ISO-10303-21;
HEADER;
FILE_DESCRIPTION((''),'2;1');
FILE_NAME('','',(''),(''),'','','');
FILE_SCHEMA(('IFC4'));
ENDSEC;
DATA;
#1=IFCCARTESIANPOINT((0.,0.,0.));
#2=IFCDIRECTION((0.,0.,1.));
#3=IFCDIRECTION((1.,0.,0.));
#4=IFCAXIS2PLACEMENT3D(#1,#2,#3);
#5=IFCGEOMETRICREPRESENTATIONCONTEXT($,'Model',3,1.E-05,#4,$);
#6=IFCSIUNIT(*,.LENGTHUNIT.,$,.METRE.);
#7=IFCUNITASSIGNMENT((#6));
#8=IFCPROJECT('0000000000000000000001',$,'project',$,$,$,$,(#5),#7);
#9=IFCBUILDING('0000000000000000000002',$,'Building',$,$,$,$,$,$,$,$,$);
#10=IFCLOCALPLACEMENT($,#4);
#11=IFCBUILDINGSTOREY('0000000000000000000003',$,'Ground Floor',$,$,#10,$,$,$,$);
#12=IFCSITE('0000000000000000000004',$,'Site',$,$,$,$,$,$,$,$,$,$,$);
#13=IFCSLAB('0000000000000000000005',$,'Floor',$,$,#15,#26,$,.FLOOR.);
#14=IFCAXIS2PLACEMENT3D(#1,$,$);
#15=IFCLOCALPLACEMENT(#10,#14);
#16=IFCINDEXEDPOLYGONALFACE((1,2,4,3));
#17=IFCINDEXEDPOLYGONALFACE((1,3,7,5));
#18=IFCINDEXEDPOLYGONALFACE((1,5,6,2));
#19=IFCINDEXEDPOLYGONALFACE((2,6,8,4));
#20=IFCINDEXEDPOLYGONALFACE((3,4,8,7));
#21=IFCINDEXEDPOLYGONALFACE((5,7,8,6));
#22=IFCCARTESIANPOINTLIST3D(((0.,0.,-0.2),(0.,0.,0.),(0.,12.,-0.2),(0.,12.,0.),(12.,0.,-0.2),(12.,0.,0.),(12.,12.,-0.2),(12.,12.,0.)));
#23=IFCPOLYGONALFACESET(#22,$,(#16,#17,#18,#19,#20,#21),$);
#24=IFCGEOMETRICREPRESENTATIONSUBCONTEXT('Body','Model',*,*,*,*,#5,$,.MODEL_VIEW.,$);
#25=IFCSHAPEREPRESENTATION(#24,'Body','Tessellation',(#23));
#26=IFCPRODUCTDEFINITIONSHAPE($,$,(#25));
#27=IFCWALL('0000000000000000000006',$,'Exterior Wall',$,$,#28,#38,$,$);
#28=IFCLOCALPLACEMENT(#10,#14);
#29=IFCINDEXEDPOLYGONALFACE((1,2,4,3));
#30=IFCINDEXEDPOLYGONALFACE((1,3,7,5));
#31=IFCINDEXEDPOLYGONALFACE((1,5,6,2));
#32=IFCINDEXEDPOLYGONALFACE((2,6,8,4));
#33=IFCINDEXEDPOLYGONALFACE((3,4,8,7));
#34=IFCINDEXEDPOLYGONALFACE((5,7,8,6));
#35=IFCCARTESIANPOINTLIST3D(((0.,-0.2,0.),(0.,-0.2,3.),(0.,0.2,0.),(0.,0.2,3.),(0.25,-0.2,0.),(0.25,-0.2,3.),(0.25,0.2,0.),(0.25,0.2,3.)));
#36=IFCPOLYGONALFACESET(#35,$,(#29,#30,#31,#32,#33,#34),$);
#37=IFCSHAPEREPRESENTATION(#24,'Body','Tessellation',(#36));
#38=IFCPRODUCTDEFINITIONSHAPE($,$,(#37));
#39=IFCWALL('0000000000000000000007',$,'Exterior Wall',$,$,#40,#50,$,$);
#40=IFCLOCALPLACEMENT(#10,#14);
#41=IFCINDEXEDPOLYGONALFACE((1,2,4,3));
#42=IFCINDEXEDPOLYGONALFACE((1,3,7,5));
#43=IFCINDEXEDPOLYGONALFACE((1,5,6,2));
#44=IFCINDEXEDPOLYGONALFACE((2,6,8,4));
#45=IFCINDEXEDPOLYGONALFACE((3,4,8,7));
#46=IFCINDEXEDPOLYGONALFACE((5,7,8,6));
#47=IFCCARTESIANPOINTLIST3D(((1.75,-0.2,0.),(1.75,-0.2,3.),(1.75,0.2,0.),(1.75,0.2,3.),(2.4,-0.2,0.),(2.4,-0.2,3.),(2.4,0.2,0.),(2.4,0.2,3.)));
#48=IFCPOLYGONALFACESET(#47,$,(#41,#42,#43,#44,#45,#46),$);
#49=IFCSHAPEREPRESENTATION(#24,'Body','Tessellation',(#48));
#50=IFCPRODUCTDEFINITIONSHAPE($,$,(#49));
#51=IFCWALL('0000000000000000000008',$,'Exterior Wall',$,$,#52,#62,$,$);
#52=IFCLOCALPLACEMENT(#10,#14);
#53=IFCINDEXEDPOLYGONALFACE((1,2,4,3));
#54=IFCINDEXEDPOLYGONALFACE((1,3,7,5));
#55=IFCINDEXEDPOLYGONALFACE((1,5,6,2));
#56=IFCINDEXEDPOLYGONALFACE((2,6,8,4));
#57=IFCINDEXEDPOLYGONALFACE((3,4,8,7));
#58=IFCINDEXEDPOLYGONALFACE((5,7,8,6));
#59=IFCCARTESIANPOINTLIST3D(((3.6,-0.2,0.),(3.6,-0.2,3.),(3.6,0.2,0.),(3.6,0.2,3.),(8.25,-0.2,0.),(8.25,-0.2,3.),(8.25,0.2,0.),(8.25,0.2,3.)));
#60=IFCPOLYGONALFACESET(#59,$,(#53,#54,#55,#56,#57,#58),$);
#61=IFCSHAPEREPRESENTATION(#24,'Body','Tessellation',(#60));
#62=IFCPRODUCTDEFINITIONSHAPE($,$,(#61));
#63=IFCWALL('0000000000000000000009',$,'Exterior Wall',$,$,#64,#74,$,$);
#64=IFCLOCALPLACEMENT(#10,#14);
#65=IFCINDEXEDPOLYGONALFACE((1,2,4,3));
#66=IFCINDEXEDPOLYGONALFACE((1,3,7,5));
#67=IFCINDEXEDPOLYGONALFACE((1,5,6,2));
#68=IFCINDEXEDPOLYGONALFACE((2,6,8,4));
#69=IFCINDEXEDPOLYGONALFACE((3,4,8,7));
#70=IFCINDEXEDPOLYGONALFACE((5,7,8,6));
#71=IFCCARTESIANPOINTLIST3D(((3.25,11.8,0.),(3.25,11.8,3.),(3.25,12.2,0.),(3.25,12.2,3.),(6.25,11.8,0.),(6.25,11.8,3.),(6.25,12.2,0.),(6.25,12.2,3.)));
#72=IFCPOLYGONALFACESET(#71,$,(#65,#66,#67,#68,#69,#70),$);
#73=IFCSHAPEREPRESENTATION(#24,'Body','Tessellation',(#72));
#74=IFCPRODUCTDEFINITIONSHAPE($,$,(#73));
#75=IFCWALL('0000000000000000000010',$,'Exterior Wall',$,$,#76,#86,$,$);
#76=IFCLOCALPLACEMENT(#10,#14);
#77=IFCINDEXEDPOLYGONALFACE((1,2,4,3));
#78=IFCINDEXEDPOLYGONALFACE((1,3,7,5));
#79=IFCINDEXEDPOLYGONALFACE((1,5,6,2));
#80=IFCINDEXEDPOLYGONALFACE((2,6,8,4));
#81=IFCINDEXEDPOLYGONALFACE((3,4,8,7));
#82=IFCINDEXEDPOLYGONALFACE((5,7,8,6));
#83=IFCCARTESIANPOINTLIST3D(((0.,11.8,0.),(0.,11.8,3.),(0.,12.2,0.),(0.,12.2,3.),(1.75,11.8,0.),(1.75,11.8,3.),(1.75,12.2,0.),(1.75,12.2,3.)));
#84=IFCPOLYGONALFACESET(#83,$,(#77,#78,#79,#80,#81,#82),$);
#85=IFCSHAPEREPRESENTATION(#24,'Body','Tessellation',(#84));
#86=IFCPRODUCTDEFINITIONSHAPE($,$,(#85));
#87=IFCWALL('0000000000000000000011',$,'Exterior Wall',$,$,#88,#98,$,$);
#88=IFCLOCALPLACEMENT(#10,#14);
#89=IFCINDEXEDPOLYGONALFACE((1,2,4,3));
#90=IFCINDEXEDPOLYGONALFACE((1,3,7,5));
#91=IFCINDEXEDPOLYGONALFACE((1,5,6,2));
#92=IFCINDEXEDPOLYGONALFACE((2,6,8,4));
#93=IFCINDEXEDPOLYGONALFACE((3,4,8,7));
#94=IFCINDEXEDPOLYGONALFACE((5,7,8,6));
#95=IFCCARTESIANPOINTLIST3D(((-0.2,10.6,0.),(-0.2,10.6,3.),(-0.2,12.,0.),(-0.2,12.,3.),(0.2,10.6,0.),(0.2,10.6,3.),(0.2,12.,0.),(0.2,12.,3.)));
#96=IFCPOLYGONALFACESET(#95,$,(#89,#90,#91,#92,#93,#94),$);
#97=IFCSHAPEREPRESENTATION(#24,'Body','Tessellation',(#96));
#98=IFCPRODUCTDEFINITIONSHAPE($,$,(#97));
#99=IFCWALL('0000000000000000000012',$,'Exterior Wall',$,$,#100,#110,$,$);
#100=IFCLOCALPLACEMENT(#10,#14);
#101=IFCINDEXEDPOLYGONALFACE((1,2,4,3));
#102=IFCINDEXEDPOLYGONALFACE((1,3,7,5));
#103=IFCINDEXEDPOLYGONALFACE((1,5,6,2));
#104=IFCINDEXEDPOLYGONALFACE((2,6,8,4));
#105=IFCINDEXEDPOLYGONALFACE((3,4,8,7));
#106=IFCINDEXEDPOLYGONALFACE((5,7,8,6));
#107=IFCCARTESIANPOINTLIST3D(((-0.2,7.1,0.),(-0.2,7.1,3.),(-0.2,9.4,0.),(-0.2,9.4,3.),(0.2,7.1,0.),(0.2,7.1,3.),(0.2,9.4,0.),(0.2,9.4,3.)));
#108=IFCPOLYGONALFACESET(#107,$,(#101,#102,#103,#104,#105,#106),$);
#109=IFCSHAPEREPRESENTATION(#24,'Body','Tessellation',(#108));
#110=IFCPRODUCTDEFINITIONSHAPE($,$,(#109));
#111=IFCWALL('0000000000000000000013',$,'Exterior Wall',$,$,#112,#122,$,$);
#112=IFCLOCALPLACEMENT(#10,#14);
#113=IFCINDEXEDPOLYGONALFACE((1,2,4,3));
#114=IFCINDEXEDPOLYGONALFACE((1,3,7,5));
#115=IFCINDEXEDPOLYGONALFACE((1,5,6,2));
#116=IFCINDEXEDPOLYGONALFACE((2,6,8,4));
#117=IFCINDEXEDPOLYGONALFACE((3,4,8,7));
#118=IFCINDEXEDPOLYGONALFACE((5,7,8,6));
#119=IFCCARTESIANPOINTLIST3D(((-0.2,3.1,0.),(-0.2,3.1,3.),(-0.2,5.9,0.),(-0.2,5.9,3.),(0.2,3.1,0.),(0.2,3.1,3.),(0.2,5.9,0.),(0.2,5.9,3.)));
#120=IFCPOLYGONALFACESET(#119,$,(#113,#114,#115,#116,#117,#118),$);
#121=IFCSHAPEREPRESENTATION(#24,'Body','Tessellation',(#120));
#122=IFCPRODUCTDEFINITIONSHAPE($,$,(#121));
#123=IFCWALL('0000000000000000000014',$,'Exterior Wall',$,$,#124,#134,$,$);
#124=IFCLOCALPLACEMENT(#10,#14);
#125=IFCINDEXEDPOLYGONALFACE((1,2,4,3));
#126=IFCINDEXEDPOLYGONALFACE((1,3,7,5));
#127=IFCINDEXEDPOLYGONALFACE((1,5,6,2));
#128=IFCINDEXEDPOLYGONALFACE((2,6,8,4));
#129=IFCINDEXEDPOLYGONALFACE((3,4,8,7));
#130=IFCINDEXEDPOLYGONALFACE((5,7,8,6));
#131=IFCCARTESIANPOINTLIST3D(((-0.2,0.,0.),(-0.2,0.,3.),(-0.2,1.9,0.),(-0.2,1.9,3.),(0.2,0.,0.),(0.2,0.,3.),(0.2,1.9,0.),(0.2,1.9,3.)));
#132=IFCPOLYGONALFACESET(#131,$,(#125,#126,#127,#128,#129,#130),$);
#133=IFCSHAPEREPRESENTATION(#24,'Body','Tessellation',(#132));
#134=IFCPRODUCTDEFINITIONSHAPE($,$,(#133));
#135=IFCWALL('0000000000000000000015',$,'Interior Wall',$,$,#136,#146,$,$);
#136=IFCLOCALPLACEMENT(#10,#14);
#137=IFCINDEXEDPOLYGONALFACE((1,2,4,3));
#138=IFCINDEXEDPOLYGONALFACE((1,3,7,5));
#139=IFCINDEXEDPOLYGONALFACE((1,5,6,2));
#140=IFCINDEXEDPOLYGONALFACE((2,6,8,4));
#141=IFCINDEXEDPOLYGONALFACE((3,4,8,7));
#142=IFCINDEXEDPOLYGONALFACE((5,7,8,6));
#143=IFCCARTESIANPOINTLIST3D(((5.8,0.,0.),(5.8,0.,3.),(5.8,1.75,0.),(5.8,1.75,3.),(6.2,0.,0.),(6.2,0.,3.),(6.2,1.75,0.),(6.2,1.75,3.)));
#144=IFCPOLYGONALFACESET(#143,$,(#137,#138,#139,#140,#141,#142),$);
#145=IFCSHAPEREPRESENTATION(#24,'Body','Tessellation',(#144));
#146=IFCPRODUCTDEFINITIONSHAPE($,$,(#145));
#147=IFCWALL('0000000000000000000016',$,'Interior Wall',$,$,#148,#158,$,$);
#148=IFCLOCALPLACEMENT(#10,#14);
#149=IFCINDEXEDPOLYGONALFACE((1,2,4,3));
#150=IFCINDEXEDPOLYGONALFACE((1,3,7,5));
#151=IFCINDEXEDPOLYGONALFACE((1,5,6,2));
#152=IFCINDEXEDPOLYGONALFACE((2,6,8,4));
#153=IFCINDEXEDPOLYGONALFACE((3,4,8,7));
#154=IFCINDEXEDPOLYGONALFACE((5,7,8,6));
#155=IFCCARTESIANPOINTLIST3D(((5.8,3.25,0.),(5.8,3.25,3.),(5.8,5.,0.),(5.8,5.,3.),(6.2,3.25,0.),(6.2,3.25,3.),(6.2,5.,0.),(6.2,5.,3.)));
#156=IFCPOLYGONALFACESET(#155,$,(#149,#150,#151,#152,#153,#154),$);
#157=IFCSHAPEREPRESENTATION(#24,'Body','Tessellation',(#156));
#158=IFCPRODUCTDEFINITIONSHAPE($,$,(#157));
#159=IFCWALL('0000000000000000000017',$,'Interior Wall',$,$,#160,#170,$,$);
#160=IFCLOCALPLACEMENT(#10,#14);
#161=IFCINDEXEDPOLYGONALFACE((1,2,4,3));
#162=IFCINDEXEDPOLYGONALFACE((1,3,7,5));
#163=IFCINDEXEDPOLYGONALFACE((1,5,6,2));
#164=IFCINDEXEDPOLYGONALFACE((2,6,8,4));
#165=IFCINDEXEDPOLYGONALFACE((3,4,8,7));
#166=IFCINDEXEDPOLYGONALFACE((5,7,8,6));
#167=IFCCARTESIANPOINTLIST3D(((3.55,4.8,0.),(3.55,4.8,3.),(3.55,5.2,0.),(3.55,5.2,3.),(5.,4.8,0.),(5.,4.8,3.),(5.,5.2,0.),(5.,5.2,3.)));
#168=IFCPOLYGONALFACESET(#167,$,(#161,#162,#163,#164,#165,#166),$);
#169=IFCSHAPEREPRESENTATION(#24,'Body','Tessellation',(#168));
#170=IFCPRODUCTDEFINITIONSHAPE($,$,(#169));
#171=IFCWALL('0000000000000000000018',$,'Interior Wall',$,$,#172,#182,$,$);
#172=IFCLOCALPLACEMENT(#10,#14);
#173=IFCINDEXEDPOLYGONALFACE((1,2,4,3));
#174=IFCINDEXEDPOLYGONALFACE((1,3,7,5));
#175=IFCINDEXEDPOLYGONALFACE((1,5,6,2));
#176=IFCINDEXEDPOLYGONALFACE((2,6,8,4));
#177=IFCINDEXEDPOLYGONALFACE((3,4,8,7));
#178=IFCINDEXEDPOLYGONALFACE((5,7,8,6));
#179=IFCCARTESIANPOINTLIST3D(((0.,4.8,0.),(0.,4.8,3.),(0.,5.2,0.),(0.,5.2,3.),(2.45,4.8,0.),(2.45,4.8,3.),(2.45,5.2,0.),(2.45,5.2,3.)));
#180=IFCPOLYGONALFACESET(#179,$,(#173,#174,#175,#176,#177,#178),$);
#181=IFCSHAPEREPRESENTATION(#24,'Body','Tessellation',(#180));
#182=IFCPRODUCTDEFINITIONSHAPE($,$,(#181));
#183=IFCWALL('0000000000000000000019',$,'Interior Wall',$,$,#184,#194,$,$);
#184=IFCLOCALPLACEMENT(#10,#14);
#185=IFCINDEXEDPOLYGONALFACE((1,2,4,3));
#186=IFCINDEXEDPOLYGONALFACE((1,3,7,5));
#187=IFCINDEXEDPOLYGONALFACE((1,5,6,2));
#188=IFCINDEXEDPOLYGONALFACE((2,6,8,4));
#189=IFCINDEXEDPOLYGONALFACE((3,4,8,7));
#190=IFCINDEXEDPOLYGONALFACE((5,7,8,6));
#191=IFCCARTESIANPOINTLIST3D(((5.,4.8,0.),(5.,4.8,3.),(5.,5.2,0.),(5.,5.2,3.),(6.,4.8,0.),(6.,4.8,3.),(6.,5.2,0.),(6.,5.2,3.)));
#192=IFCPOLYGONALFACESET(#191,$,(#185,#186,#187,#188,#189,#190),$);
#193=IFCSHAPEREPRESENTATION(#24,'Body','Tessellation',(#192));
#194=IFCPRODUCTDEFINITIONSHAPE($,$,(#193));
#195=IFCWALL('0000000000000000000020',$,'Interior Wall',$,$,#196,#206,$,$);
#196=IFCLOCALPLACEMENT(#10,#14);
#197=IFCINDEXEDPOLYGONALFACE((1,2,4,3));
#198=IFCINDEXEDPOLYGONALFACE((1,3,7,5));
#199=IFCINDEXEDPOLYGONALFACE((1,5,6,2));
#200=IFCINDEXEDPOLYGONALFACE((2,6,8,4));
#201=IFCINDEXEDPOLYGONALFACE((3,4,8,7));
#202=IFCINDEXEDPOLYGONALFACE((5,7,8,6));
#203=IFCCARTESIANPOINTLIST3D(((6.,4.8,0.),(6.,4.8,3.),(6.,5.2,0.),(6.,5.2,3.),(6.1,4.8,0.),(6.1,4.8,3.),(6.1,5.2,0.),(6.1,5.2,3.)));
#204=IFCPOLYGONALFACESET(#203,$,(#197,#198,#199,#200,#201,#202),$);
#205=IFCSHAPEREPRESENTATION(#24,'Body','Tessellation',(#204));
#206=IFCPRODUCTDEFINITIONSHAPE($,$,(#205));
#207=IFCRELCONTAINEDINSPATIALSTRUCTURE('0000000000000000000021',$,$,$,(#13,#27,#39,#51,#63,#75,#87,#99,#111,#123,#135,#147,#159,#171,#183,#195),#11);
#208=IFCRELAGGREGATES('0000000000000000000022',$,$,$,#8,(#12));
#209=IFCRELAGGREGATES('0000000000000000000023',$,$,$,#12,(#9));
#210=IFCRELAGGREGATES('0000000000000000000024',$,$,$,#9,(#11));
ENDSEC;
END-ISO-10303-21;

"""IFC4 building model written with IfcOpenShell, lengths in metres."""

from ifc_helpers import new_model, si_unit, frame, origin_with_axes, place, context, subcontext, project, spatial, indexed_curve, outline, extrude, element, save


model = new_model("IFC4")

# Units and contexts
model_context = context("Model", 3, precision=1e-05, world=origin_with_axes())
body_context = subcontext(model_context, "Body", "Model", "MODEL_VIEW")
ifc_project = project(units=[si_unit("LENGTHUNIT", "METRE")], contexts=[model_context])

# Site, building, storey
site = spatial("IfcSite", under=ifc_project, Name="Site")
building = spatial("IfcBuilding", under=site, Name="Building")
storey_placement = place(None, origin_with_axes())
storey = spatial("IfcBuildingStorey", under=building, at=storey_placement, Name="Ground Floor")

# Slab
slab_placement = place(storey_placement, frame((0.0, 0.0, -0.2), z_axis=(0.0, 0.0, 1.0), x_axis=(1.0, 0.0, 0.0)))
element("IfcSlab", 1, at=slab_placement, inside=storey, Name="Floor", PredefinedType="FLOOR", context=body_context, shape_type="SweptSolid", body=[
    extrude(outline(indexed_curve([(0.0, 0.0), (12.0, 0.0), (12.0, 12.0), (0.0, 12.0)])), None, (0.0, 0.0, 1.0), 0.2),
])

# Walls
wall_1_placement = place(storey_placement, origin_with_axes())
element("IfcWall", 2, at=wall_1_placement, inside=storey, Name="Exterior Wall", context=body_context, shape_type="SweptSolid", body=[
    extrude(outline(indexed_curve([(0.0, 0.0), (0.0, 0.4), (0.25, 0.4), (0.25, 0.0), (0.0, 0.0)], self_intersect=False)), frame((0.0, -0.2, 0.0), z_axis=(0.0, 0.0, 1.0), x_axis=(1.0, 0.0, 0.0)), (0.0, 0.0, 1.0), 3.0),
])
wall_2_placement = place(storey_placement, frame((1.75, 0.0, 0.0), z_axis=(0.0, 0.0, 1.0), x_axis=(1.0, 0.0, 0.0)))
element("IfcWall", 3, at=wall_2_placement, inside=storey, Name="Exterior Wall", context=body_context, shape_type="SweptSolid", body=[
    extrude(outline(indexed_curve([(0.0, 0.0), (0.0, 0.4), (0.65, 0.4), (0.65, 0.0), (0.0, 0.0)], self_intersect=False)), frame((0.0, -0.2, 0.0), z_axis=(0.0, 0.0, 1.0), x_axis=(1.0, 0.0, 0.0)), (0.0, 0.0, 1.0), 3.0),
])
wall_3_placement = place(storey_placement, frame((3.6, 0.0, 0.0), z_axis=(0.0, 0.0, 1.0), x_axis=(1.0, 0.0, 0.0)))
element("IfcWall", 4, at=wall_3_placement, inside=storey, Name="Exterior Wall", context=body_context, shape_type="SweptSolid", body=[
    extrude(outline(indexed_curve([(0.0, 0.0), (0.0, 0.4), (4.65, 0.4), (4.65, 0.0), (0.0, 0.0)], self_intersect=False)), frame((0.0, -0.2, 0.0), z_axis=(0.0, 0.0, 1.0), x_axis=(1.0, 0.0, 0.0)), (0.0, 0.0, 1.0), 3.0),
])
wall_4_placement = place(storey_placement, frame((6.25, 12.0, 0.0), z_axis=(0.0, 0.0, 1.0), x_axis=(-1.0, 0.0, 0.0)))
element("IfcWall", 5, at=wall_4_placement, inside=storey, Name="Exterior Wall", context=body_context, shape_type="SweptSolid", body=[
    extrude(outline(indexed_curve([(0.0, 0.0), (0.0, 0.4), (3.0, 0.4), (3.0, 0.0), (0.0, 0.0)], self_intersect=False)), frame((0.0, -0.2, 0.0), z_axis=(0.0, 0.0, 1.0), x_axis=(1.0, 0.0, 0.0)), (0.0, 0.0, 1.0), 3.0),
])
wall_5_placement = place(storey_placement, frame((1.75, 12.0, 0.0), z_axis=(0.0, 0.0, 1.0), x_axis=(-1.0, 0.0, 0.0)))
element("IfcWall", 6, at=wall_5_placement, inside=storey, Name="Exterior Wall", context=body_context, shape_type="SweptSolid", body=[
    extrude(outline(indexed_curve([(0.0, 0.0), (0.0, 0.4), (1.75, 0.4), (1.75, 0.0), (0.0, 0.0)], self_intersect=False)), frame((0.0, -0.2, 0.0), z_axis=(0.0, 0.0, 1.0), x_axis=(1.0, 0.0, 0.0)), (0.0, 0.0, 1.0), 3.0),
])
wall_6_placement = place(storey_placement, frame((0.0, 12.0, 0.0), z_axis=(0.0, 0.0, 1.0), x_axis=(0.0, -1.0, 0.0)))
element("IfcWall", 7, at=wall_6_placement, inside=storey, Name="Exterior Wall", context=body_context, shape_type="SweptSolid", body=[
    extrude(outline(indexed_curve([(0.0, 0.0), (0.0, 0.4), (1.4, 0.4), (1.4, 0.0), (0.0, 0.0)], self_intersect=False)), frame((0.0, -0.2, 0.0), z_axis=(0.0, 0.0, 1.0), x_axis=(1.0, 0.0, 0.0)), (0.0, 0.0, 1.0), 3.0),
])
wall_7_placement = place(storey_placement, frame((0.0, 9.4, 0.0), z_axis=(0.0, 0.0, 1.0), x_axis=(0.0, -1.0, 0.0)))
element("IfcWall", 8, at=wall_7_placement, inside=storey, Name="Exterior Wall", context=body_context, shape_type="SweptSolid", body=[
    extrude(outline(indexed_curve([(0.0, 0.0), (0.0, 0.4), (2.3, 0.4), (2.3, 0.0), (0.0, 0.0)], self_intersect=False)), frame((0.0, -0.2, 0.0), z_axis=(0.0, 0.0, 1.0), x_axis=(1.0, 0.0, 0.0)), (0.0, 0.0, 1.0), 3.0),
])
wall_8_placement = place(storey_placement, frame((0.0, 5.9, 0.0), z_axis=(0.0, 0.0, 1.0), x_axis=(0.0, -1.0, 0.0)))
element("IfcWall", 9, at=wall_8_placement, inside=storey, Name="Exterior Wall", context=body_context, shape_type="SweptSolid", body=[
    extrude(outline(indexed_curve([(0.0, 0.0), (0.0, 0.4), (2.8, 0.4), (2.8, 0.0), (0.0, 0.0)], self_intersect=False)), frame((0.0, -0.2, 0.0), z_axis=(0.0, 0.0, 1.0), x_axis=(1.0, 0.0, 0.0)), (0.0, 0.0, 1.0), 3.0),
])
wall_9_placement = place(storey_placement, frame((0.0, 1.9, 0.0), z_axis=(0.0, 0.0, 1.0), x_axis=(0.0, -1.0, 0.0)))
element("IfcWall", 10, at=wall_9_placement, inside=storey, Name="Exterior Wall", context=body_context, shape_type="SweptSolid", body=[
    extrude(outline(indexed_curve([(0.0, 0.0), (0.0, 0.4), (1.9, 0.4), (1.9, 0.0), (0.0, 0.0)], self_intersect=False)), frame((0.0, -0.2, 0.0), z_axis=(0.0, 0.0, 1.0), x_axis=(1.0, 0.0, 0.0)), (0.0, 0.0, 1.0), 3.0),
])
for number, where, z_axis, x_axis, name in (
    (11, (6.0, 0.0, 0.0), (0.0, 0.0, 1.0), (0.0, 1.0, 0.0), "Interior Wall"),
    (12, (6.0, 3.25, 0.0), (0.0, 0.0, 1.0), (0.0, 1.0, 0.0), "Interior Wall"),
):
    element("IfcWall", number, at=place(storey_placement, frame(where, z_axis=z_axis, x_axis=x_axis)), inside=storey, Name=name, context=body_context, shape_type="SweptSolid", body=[
        extrude(outline(indexed_curve([(0.0, 0.0), (0.0, 0.4), (1.75, 0.4), (1.75, 0.0), (0.0, 0.0)], self_intersect=False)), frame((0.0, -0.2, 0.0), z_axis=(0.0, 0.0, 1.0), x_axis=(1.0, 0.0, 0.0)), (0.0, 0.0, 1.0), 3.0),
    ])
wall_10_placement = place(storey_placement, frame((5.0, 5.0, 0.0), z_axis=(0.0, 0.0, 1.0), x_axis=(-1.0, 0.0, 0.0)))
element("IfcWall", 13, at=wall_10_placement, inside=storey, Name="Interior Wall", context=body_context, shape_type="SweptSolid", body=[
    extrude(outline(indexed_curve([(0.0, 0.0), (0.0, 0.4), (1.45, 0.4), (1.45, 0.0), (0.0, 0.0)], self_intersect=False)), frame((0.0, -0.2, 0.0), z_axis=(0.0, 0.0, 1.0), x_axis=(1.0, 0.0, 0.0)), (0.0, 0.0, 1.0), 3.0),
])
wall_11_placement = place(storey_placement, frame((2.45, 5.0, 0.0), z_axis=(0.0, 0.0, 1.0), x_axis=(-1.0, 0.0, 0.0)))
element("IfcWall", 14, at=wall_11_placement, inside=storey, Name="Interior Wall", context=body_context, shape_type="SweptSolid", body=[
    extrude(outline(indexed_curve([(0.0, 0.0), (0.0, 0.4), (2.45, 0.4), (2.45, 0.0), (0.0, 0.0)], self_intersect=False)), frame((0.0, -0.2, 0.0), z_axis=(0.0, 0.0, 1.0), x_axis=(1.0, 0.0, 0.0)), (0.0, 0.0, 1.0), 3.0),
])
wall_12_placement = place(storey_placement, frame((6.0, 5.0, 0.0), z_axis=(0.0, 0.0, 1.0), x_axis=(-1.0, 0.0, 0.0)))
element("IfcWall", 15, at=wall_12_placement, inside=storey, Name="Interior Wall", context=body_context, shape_type="SweptSolid", body=[
    extrude(outline(indexed_curve([(0.0, 0.0), (0.0, 0.4), (1.0, 0.4), (1.0, 0.0), (0.0, 0.0)], self_intersect=False)), frame((0.0, -0.2, 0.0), z_axis=(0.0, 0.0, 1.0), x_axis=(1.0, 0.0, 0.0)), (0.0, 0.0, 1.0), 3.0),
])
wall_13_placement = place(storey_placement, frame((6.1, 5.0, 0.0), z_axis=(0.0, 0.0, 1.0), x_axis=(-1.0, 0.0, 0.0)))
element("IfcWall", 16, at=wall_13_placement, inside=storey, Name="Interior Wall", context=body_context, shape_type="SweptSolid", body=[
    extrude(outline(indexed_curve([(0.0, 0.0), (0.0, 0.4), (0.1, 0.4), (0.1, 0.0), (0.0, 0.0)], self_intersect=False)), frame((0.0, -0.2, 0.0), z_axis=(0.0, 0.0, 1.0), x_axis=(1.0, 0.0, 0.0)), (0.0, 0.0, 1.0), 3.0),
])

save(model, "model.ifc")
